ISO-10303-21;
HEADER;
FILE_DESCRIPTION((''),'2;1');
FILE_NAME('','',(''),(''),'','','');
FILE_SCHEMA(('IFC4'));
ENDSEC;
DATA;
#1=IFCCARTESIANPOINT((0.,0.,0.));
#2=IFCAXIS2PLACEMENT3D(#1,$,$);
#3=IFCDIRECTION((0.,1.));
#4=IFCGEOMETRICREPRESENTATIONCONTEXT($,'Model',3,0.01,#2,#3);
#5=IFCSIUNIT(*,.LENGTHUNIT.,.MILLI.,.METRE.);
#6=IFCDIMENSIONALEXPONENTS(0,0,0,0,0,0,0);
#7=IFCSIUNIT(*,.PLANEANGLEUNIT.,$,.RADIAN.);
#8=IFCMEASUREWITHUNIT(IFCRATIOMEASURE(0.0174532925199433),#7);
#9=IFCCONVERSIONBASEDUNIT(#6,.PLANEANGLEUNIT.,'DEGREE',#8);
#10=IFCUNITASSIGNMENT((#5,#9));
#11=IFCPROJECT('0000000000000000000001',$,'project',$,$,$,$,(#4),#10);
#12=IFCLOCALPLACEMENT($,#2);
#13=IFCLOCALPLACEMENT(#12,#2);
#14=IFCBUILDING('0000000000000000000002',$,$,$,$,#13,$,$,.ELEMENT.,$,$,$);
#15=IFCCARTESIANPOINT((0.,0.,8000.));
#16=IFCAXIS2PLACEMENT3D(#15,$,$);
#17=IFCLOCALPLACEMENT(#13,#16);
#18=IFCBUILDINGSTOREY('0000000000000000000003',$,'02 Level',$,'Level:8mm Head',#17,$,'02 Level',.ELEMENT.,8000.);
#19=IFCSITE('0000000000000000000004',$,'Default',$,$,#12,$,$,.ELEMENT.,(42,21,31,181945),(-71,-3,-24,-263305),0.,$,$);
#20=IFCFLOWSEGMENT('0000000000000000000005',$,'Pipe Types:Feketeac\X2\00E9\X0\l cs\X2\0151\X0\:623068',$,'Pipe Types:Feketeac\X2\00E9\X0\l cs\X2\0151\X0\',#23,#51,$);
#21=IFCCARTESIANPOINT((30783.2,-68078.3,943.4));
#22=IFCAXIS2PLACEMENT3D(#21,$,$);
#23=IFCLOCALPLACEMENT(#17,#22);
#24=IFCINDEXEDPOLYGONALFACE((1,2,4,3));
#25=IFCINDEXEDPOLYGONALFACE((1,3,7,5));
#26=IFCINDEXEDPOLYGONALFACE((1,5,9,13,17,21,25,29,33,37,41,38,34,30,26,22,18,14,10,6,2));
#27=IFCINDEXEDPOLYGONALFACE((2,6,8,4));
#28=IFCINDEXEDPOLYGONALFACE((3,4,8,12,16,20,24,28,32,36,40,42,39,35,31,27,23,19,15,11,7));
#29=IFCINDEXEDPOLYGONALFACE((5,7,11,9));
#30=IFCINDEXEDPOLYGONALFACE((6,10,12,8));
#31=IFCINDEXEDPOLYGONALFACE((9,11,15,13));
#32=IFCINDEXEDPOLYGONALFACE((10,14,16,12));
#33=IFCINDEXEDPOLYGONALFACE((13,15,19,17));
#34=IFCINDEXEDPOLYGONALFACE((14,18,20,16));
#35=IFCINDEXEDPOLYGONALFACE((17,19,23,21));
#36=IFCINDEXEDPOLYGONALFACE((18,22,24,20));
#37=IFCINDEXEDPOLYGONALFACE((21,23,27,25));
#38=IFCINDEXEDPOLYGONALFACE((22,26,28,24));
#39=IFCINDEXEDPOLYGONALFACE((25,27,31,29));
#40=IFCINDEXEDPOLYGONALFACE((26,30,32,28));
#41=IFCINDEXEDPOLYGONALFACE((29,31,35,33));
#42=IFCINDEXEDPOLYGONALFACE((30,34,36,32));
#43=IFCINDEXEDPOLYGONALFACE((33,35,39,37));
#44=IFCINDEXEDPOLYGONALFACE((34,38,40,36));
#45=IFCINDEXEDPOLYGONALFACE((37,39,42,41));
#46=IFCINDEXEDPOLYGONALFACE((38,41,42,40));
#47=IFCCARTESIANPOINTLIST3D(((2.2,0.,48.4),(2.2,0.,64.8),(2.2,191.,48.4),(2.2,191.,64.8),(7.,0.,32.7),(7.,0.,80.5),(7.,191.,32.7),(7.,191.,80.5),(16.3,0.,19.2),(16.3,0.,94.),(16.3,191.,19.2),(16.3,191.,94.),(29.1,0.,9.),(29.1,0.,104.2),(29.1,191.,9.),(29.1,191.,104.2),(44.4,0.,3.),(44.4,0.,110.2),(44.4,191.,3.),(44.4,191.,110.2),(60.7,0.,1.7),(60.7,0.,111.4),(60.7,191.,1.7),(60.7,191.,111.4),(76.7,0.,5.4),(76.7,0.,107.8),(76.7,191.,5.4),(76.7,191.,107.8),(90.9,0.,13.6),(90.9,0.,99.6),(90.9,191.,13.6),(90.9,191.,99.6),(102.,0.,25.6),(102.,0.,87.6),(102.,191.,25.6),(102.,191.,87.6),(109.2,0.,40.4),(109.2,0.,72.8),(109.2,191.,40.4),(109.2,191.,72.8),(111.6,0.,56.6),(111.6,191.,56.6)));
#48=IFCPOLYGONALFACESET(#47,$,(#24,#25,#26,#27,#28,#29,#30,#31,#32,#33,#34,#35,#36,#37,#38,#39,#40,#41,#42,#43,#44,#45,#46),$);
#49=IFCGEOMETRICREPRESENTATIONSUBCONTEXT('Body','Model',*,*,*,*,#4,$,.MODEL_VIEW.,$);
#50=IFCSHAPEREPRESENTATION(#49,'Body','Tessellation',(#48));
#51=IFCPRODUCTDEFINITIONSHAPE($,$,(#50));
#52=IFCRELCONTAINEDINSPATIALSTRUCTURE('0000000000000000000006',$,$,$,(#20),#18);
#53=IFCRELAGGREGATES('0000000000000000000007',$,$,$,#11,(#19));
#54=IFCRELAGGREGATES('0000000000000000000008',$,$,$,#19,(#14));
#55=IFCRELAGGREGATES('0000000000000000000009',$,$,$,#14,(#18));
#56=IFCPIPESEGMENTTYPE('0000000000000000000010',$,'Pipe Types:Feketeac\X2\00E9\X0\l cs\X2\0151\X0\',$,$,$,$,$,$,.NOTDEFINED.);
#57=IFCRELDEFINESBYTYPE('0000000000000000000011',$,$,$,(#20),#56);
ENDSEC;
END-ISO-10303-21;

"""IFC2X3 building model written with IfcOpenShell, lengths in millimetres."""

from ifc_helpers import new_model, entity, si_unit, converted_unit, direction, frame, origin, origin_2d_with_axis, place, context, subcontext, project, spatial, circle, extrude, type_object, element, save


model = new_model("IFC2X3")

# Units and contexts
model_context = context("Model", 3, precision=0.01, world=origin(), true_north=direction((0.0, 1.0)))
body_context = subcontext(model_context, "Body", "Model", "MODEL_VIEW")
ifc_project = project(units=[si_unit("LENGTHUNIT", "METRE", prefix="MILLI"), converted_unit("PLANEANGLEUNIT", "DEGREE", entity("IfcRatioMeasure", 0.0174532925199433), si_unit("PLANEANGLEUNIT", "RADIAN"), dimensions=[0, 0, 0, 0, 0, 0, 0])], contexts=[model_context])

# Site, building, storey
site_placement = place(None, origin())
site = spatial("IfcSite", under=ifc_project, at=site_placement, Name="Default", CompositionType="ELEMENT", RefLatitude=(42, 21, 31, 181945), RefLongitude=(-71, -3, -24, -263305), RefElevation=0.0)
building_placement = place(site_placement, origin())
building = spatial("IfcBuilding", under=site, at=building_placement, CompositionType="ELEMENT")
storey_placement = place(building_placement, frame((0.0, 0.0, 8000.0)))
storey = spatial("IfcBuildingStorey", under=building, at=storey_placement, Name="02 Level", ObjectType="Level:8mm Head", LongName="02 Level", CompositionType="ELEMENT", Elevation=8000.0)

# Flow segment
pipe_segment_type = type_object("IfcPipeSegmentType", Name="Pipe Types:Feketeacél cső", PredefinedType="NOTDEFINED")
flow_segment_placement = place(storey_placement, frame((30783.2, -68078.3, 943.4)))
element("IfcFlowSegment", 1, at=flow_segment_placement, inside=storey, type_object=pipe_segment_type, Name="Pipe Types:Feketeacél cső:623068", ObjectType="Pipe Types:Feketeacél cső", context=body_context, shape_type="SweptSolid", body=[
    extrude(circle(Radius=55.0, at=origin_2d_with_axis()), frame((56.6, 0.0, 56.6), z_axis=(0.0, 1.0, 0.0), x_axis=(1.0, 0.0, 0.0)), (0.0, 0.0, 1.0), 191.0),
])

save(model, "model.ifc")
